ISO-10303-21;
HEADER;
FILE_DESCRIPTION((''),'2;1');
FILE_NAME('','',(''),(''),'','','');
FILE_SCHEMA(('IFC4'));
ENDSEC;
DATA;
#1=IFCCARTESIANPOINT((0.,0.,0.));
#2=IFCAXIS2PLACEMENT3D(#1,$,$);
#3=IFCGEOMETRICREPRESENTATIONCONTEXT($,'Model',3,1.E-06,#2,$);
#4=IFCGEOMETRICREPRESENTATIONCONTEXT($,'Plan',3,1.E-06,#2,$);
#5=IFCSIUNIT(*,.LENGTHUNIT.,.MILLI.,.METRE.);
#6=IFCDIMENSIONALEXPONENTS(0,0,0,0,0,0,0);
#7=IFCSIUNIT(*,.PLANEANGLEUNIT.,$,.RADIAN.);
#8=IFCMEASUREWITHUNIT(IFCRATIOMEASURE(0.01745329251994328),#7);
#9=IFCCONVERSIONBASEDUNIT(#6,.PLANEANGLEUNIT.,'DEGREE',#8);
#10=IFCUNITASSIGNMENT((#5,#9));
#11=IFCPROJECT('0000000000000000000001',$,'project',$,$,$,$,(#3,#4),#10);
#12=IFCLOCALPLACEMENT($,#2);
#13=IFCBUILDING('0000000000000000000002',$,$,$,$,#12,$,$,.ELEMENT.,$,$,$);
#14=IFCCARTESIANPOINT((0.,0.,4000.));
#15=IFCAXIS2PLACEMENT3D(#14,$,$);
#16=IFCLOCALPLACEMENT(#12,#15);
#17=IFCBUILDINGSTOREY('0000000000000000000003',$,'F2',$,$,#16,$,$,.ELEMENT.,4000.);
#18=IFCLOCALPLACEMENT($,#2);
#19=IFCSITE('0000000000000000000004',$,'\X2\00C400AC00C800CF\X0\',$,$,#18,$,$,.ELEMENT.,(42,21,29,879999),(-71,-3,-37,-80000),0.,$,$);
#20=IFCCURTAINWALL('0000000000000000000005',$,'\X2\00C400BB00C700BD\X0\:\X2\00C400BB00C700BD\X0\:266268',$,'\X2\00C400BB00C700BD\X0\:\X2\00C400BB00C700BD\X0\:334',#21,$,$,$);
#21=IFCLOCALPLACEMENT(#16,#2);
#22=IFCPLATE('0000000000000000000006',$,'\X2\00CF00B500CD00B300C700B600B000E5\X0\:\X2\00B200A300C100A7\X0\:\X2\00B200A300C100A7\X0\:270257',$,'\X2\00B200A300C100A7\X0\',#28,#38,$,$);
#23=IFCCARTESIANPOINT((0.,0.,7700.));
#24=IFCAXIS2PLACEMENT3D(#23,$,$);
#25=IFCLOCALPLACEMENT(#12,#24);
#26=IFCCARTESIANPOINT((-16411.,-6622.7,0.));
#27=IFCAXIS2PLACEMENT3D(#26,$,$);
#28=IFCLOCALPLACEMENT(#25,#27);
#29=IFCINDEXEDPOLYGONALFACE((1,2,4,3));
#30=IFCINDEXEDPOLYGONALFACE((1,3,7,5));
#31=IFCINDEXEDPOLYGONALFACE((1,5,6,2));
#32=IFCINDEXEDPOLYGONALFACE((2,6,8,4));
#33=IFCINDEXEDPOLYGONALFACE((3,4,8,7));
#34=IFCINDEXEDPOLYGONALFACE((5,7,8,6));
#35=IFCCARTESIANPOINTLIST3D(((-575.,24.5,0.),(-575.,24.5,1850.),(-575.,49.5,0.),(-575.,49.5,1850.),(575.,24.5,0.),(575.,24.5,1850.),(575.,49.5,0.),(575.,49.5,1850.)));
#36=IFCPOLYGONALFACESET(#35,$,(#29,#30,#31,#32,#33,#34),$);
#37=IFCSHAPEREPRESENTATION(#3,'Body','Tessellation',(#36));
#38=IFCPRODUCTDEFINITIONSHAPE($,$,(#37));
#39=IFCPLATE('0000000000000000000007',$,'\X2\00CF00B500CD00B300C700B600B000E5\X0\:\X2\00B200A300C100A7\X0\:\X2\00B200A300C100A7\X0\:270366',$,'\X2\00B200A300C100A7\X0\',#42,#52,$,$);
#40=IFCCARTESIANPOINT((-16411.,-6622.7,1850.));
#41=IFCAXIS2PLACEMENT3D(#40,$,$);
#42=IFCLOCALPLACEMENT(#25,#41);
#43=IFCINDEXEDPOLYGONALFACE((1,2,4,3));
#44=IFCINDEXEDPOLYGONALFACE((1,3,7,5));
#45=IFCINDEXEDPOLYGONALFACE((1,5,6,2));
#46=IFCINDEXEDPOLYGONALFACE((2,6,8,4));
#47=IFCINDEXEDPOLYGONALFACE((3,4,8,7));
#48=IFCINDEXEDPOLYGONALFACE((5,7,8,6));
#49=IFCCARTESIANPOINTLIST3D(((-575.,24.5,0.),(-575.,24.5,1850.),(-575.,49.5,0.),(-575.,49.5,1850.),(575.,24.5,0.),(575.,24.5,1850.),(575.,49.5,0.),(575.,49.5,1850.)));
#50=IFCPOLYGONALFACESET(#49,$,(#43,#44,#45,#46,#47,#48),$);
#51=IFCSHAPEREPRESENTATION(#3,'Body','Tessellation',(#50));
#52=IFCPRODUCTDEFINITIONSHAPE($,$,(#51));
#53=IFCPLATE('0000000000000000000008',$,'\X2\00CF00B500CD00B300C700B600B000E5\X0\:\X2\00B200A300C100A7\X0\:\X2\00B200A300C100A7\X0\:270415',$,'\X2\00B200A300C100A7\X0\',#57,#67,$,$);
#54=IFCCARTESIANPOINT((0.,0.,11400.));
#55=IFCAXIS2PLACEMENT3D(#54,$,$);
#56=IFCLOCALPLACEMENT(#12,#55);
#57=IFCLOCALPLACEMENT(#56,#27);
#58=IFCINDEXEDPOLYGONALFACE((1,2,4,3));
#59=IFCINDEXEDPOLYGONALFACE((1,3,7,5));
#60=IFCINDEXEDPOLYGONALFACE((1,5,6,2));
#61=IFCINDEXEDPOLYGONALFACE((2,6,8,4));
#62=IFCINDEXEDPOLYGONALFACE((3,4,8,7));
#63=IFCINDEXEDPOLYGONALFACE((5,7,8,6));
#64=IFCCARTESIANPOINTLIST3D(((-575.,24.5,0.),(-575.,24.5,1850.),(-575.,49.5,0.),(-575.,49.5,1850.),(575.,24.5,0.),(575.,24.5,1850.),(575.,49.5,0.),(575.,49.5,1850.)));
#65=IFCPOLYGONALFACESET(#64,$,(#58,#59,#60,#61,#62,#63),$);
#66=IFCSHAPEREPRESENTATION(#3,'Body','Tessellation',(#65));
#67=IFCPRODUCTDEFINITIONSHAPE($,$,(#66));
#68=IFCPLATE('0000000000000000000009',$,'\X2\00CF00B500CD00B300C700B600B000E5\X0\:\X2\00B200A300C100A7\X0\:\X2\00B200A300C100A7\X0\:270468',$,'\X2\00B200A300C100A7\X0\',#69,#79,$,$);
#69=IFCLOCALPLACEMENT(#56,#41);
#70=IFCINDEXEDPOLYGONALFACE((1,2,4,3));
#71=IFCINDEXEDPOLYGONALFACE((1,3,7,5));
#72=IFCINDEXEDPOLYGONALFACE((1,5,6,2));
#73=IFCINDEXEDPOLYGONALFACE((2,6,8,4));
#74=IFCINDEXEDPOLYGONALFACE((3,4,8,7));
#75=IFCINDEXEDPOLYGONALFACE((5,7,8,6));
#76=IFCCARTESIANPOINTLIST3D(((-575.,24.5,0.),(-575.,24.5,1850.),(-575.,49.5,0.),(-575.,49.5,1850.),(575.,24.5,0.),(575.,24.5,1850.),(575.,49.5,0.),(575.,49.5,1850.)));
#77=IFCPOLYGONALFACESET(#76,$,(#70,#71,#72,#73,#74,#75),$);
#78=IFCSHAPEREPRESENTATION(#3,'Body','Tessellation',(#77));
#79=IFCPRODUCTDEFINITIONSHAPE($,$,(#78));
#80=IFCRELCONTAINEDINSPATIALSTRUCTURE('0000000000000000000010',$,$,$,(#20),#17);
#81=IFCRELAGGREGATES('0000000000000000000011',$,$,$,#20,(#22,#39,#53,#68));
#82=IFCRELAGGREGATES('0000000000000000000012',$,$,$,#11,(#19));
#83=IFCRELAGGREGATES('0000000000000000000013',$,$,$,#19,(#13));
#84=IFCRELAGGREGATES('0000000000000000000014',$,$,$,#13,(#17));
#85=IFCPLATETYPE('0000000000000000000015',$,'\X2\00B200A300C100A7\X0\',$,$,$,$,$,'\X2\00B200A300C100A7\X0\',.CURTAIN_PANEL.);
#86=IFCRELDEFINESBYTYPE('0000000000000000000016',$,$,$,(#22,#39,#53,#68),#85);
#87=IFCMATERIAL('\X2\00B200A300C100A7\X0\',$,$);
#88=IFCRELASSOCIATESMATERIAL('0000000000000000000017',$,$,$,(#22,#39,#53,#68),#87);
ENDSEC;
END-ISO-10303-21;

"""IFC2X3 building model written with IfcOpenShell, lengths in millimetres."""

from ifc_helpers import new_model, entity, si_unit, converted_unit, frame, origin, origin_2d_with_axis, place, context, project, spatial, rectangle, extrude, source, transform, mapped, material, type_object, type_shapes, element, aggregate, save


model = new_model("IFC2X3")

# Units and contexts
model_context = context("Model", 3, precision=1e-06, world=origin())
plan_context = context("Plan", 3, precision=1e-06, world=origin())
ifc_project = project(units=[si_unit("LENGTHUNIT", "METRE", prefix="MILLI"), converted_unit("PLANEANGLEUNIT", "DEGREE", entity("IfcRatioMeasure", 0.01745329251994328), si_unit("PLANEANGLEUNIT", "RADIAN"), dimensions=[0, 0, 0, 0, 0, 0, 0])], contexts=[model_context, plan_context])

# Site, building, storey
site_placement = place(None, origin())
site = spatial("IfcSite", under=ifc_project, at=site_placement, Name="Ä¬ÈÏ", CompositionType="ELEMENT", RefLatitude=(42, 21, 29, 879999), RefLongitude=(-71, -3, -37, -80000), RefElevation=0.0)
building_placement = place(None, origin())
building = spatial("IfcBuilding", under=site, at=building_placement, CompositionType="ELEMENT")
storey_placement = place(building_placement, frame((0.0, 0.0, 4000.0)))
storey = spatial("IfcBuildingStorey", under=building, at=storey_placement, Name="F2", CompositionType="ELEMENT", Elevation=4000.0)

# Curtain wall, plates
curtain_wall_placement = place(storey_placement, origin())
curtain_wall = element("IfcCurtainWall", 1, at=curtain_wall_placement, inside=storey, Name="Ä»Ç½:Ä»Ç½:266268", ObjectType="Ä»Ç½:Ä»Ç½:334")
placement_1 = place(building_placement, frame((0.0, 0.0, 11400.0)))
placement_2 = place(building_placement, frame((0.0, 0.0, 7700.0)))
ifc_material_1 = material(Name="²£Á§")
plate_type = type_object("IfcPlateType", Name="²£Á§", ElementType="²£Á§", PredefinedType="CURTAIN_PANEL")
shared_shape_1 = source(origin(), model_context, "Body", "SweptSolid", [
    extrude(rectangle(XDim=25.0, YDim=1150.0, at=origin_2d_with_axis()), frame((0.0, 37.0, 0.0), z_axis=(0.0, 0.0, 1.0), x_axis=(0.0, 1.0, 0.0)), (0.0, 0.0, 1.0), 1850.0),
])
type_shapes(plate_type, [shared_shape_1])
plate_1_placement = place(placement_2, frame((-16411.0, -6622.7, 0.0)))
plate_1 = element("IfcPlate", 2, at=plate_1_placement, type_object=plate_type, material=ifc_material_1, Name="ÏµÍ³Ç¶°å:²£Á§:²£Á§:270257", ObjectType="²£Á§", context=model_context, shape_type="MappedRepresentation", body=[
    mapped(shared_shape_1, transform((0.0, 0.0, 0.0), scale=1.0)),
])
plate_2_placement = place(placement_2, frame((-16411.0, -6622.7, 1850.0)))
plate_2 = element("IfcPlate", 3, at=plate_2_placement, type_object=plate_type, material=ifc_material_1, Name="ÏµÍ³Ç¶°å:²£Á§:²£Á§:270366", ObjectType="²£Á§", context=model_context, shape_type="MappedRepresentation", body=[
    mapped(shared_shape_1, transform((0.0, 0.0, 0.0), scale=1.0)),
])
plate_3_placement = place(placement_1, frame((-16411.0, -6622.7, 0.0)))
plate_3 = element("IfcPlate", 4, at=plate_3_placement, type_object=plate_type, material=ifc_material_1, Name="ÏµÍ³Ç¶°å:²£Á§:²£Á§:270415", ObjectType="²£Á§", context=model_context, shape_type="MappedRepresentation", body=[
    mapped(shared_shape_1, transform((0.0, 0.0, 0.0), scale=1.0)),
])
plate_4_placement = place(placement_1, frame((-16411.0, -6622.7, 1850.0)))
plate_4 = element("IfcPlate", 5, at=plate_4_placement, type_object=plate_type, material=ifc_material_1, Name="ÏµÍ³Ç¶°å:²£Á§:²£Á§:270468", ObjectType="²£Á§", context=model_context, shape_type="MappedRepresentation", body=[
    mapped(shared_shape_1, transform((0.0, 0.0, 0.0), scale=1.0)),
])
aggregate(curtain_wall, [plate_1, plate_2, plate_3, plate_4])

save(model, "model.ifc")
